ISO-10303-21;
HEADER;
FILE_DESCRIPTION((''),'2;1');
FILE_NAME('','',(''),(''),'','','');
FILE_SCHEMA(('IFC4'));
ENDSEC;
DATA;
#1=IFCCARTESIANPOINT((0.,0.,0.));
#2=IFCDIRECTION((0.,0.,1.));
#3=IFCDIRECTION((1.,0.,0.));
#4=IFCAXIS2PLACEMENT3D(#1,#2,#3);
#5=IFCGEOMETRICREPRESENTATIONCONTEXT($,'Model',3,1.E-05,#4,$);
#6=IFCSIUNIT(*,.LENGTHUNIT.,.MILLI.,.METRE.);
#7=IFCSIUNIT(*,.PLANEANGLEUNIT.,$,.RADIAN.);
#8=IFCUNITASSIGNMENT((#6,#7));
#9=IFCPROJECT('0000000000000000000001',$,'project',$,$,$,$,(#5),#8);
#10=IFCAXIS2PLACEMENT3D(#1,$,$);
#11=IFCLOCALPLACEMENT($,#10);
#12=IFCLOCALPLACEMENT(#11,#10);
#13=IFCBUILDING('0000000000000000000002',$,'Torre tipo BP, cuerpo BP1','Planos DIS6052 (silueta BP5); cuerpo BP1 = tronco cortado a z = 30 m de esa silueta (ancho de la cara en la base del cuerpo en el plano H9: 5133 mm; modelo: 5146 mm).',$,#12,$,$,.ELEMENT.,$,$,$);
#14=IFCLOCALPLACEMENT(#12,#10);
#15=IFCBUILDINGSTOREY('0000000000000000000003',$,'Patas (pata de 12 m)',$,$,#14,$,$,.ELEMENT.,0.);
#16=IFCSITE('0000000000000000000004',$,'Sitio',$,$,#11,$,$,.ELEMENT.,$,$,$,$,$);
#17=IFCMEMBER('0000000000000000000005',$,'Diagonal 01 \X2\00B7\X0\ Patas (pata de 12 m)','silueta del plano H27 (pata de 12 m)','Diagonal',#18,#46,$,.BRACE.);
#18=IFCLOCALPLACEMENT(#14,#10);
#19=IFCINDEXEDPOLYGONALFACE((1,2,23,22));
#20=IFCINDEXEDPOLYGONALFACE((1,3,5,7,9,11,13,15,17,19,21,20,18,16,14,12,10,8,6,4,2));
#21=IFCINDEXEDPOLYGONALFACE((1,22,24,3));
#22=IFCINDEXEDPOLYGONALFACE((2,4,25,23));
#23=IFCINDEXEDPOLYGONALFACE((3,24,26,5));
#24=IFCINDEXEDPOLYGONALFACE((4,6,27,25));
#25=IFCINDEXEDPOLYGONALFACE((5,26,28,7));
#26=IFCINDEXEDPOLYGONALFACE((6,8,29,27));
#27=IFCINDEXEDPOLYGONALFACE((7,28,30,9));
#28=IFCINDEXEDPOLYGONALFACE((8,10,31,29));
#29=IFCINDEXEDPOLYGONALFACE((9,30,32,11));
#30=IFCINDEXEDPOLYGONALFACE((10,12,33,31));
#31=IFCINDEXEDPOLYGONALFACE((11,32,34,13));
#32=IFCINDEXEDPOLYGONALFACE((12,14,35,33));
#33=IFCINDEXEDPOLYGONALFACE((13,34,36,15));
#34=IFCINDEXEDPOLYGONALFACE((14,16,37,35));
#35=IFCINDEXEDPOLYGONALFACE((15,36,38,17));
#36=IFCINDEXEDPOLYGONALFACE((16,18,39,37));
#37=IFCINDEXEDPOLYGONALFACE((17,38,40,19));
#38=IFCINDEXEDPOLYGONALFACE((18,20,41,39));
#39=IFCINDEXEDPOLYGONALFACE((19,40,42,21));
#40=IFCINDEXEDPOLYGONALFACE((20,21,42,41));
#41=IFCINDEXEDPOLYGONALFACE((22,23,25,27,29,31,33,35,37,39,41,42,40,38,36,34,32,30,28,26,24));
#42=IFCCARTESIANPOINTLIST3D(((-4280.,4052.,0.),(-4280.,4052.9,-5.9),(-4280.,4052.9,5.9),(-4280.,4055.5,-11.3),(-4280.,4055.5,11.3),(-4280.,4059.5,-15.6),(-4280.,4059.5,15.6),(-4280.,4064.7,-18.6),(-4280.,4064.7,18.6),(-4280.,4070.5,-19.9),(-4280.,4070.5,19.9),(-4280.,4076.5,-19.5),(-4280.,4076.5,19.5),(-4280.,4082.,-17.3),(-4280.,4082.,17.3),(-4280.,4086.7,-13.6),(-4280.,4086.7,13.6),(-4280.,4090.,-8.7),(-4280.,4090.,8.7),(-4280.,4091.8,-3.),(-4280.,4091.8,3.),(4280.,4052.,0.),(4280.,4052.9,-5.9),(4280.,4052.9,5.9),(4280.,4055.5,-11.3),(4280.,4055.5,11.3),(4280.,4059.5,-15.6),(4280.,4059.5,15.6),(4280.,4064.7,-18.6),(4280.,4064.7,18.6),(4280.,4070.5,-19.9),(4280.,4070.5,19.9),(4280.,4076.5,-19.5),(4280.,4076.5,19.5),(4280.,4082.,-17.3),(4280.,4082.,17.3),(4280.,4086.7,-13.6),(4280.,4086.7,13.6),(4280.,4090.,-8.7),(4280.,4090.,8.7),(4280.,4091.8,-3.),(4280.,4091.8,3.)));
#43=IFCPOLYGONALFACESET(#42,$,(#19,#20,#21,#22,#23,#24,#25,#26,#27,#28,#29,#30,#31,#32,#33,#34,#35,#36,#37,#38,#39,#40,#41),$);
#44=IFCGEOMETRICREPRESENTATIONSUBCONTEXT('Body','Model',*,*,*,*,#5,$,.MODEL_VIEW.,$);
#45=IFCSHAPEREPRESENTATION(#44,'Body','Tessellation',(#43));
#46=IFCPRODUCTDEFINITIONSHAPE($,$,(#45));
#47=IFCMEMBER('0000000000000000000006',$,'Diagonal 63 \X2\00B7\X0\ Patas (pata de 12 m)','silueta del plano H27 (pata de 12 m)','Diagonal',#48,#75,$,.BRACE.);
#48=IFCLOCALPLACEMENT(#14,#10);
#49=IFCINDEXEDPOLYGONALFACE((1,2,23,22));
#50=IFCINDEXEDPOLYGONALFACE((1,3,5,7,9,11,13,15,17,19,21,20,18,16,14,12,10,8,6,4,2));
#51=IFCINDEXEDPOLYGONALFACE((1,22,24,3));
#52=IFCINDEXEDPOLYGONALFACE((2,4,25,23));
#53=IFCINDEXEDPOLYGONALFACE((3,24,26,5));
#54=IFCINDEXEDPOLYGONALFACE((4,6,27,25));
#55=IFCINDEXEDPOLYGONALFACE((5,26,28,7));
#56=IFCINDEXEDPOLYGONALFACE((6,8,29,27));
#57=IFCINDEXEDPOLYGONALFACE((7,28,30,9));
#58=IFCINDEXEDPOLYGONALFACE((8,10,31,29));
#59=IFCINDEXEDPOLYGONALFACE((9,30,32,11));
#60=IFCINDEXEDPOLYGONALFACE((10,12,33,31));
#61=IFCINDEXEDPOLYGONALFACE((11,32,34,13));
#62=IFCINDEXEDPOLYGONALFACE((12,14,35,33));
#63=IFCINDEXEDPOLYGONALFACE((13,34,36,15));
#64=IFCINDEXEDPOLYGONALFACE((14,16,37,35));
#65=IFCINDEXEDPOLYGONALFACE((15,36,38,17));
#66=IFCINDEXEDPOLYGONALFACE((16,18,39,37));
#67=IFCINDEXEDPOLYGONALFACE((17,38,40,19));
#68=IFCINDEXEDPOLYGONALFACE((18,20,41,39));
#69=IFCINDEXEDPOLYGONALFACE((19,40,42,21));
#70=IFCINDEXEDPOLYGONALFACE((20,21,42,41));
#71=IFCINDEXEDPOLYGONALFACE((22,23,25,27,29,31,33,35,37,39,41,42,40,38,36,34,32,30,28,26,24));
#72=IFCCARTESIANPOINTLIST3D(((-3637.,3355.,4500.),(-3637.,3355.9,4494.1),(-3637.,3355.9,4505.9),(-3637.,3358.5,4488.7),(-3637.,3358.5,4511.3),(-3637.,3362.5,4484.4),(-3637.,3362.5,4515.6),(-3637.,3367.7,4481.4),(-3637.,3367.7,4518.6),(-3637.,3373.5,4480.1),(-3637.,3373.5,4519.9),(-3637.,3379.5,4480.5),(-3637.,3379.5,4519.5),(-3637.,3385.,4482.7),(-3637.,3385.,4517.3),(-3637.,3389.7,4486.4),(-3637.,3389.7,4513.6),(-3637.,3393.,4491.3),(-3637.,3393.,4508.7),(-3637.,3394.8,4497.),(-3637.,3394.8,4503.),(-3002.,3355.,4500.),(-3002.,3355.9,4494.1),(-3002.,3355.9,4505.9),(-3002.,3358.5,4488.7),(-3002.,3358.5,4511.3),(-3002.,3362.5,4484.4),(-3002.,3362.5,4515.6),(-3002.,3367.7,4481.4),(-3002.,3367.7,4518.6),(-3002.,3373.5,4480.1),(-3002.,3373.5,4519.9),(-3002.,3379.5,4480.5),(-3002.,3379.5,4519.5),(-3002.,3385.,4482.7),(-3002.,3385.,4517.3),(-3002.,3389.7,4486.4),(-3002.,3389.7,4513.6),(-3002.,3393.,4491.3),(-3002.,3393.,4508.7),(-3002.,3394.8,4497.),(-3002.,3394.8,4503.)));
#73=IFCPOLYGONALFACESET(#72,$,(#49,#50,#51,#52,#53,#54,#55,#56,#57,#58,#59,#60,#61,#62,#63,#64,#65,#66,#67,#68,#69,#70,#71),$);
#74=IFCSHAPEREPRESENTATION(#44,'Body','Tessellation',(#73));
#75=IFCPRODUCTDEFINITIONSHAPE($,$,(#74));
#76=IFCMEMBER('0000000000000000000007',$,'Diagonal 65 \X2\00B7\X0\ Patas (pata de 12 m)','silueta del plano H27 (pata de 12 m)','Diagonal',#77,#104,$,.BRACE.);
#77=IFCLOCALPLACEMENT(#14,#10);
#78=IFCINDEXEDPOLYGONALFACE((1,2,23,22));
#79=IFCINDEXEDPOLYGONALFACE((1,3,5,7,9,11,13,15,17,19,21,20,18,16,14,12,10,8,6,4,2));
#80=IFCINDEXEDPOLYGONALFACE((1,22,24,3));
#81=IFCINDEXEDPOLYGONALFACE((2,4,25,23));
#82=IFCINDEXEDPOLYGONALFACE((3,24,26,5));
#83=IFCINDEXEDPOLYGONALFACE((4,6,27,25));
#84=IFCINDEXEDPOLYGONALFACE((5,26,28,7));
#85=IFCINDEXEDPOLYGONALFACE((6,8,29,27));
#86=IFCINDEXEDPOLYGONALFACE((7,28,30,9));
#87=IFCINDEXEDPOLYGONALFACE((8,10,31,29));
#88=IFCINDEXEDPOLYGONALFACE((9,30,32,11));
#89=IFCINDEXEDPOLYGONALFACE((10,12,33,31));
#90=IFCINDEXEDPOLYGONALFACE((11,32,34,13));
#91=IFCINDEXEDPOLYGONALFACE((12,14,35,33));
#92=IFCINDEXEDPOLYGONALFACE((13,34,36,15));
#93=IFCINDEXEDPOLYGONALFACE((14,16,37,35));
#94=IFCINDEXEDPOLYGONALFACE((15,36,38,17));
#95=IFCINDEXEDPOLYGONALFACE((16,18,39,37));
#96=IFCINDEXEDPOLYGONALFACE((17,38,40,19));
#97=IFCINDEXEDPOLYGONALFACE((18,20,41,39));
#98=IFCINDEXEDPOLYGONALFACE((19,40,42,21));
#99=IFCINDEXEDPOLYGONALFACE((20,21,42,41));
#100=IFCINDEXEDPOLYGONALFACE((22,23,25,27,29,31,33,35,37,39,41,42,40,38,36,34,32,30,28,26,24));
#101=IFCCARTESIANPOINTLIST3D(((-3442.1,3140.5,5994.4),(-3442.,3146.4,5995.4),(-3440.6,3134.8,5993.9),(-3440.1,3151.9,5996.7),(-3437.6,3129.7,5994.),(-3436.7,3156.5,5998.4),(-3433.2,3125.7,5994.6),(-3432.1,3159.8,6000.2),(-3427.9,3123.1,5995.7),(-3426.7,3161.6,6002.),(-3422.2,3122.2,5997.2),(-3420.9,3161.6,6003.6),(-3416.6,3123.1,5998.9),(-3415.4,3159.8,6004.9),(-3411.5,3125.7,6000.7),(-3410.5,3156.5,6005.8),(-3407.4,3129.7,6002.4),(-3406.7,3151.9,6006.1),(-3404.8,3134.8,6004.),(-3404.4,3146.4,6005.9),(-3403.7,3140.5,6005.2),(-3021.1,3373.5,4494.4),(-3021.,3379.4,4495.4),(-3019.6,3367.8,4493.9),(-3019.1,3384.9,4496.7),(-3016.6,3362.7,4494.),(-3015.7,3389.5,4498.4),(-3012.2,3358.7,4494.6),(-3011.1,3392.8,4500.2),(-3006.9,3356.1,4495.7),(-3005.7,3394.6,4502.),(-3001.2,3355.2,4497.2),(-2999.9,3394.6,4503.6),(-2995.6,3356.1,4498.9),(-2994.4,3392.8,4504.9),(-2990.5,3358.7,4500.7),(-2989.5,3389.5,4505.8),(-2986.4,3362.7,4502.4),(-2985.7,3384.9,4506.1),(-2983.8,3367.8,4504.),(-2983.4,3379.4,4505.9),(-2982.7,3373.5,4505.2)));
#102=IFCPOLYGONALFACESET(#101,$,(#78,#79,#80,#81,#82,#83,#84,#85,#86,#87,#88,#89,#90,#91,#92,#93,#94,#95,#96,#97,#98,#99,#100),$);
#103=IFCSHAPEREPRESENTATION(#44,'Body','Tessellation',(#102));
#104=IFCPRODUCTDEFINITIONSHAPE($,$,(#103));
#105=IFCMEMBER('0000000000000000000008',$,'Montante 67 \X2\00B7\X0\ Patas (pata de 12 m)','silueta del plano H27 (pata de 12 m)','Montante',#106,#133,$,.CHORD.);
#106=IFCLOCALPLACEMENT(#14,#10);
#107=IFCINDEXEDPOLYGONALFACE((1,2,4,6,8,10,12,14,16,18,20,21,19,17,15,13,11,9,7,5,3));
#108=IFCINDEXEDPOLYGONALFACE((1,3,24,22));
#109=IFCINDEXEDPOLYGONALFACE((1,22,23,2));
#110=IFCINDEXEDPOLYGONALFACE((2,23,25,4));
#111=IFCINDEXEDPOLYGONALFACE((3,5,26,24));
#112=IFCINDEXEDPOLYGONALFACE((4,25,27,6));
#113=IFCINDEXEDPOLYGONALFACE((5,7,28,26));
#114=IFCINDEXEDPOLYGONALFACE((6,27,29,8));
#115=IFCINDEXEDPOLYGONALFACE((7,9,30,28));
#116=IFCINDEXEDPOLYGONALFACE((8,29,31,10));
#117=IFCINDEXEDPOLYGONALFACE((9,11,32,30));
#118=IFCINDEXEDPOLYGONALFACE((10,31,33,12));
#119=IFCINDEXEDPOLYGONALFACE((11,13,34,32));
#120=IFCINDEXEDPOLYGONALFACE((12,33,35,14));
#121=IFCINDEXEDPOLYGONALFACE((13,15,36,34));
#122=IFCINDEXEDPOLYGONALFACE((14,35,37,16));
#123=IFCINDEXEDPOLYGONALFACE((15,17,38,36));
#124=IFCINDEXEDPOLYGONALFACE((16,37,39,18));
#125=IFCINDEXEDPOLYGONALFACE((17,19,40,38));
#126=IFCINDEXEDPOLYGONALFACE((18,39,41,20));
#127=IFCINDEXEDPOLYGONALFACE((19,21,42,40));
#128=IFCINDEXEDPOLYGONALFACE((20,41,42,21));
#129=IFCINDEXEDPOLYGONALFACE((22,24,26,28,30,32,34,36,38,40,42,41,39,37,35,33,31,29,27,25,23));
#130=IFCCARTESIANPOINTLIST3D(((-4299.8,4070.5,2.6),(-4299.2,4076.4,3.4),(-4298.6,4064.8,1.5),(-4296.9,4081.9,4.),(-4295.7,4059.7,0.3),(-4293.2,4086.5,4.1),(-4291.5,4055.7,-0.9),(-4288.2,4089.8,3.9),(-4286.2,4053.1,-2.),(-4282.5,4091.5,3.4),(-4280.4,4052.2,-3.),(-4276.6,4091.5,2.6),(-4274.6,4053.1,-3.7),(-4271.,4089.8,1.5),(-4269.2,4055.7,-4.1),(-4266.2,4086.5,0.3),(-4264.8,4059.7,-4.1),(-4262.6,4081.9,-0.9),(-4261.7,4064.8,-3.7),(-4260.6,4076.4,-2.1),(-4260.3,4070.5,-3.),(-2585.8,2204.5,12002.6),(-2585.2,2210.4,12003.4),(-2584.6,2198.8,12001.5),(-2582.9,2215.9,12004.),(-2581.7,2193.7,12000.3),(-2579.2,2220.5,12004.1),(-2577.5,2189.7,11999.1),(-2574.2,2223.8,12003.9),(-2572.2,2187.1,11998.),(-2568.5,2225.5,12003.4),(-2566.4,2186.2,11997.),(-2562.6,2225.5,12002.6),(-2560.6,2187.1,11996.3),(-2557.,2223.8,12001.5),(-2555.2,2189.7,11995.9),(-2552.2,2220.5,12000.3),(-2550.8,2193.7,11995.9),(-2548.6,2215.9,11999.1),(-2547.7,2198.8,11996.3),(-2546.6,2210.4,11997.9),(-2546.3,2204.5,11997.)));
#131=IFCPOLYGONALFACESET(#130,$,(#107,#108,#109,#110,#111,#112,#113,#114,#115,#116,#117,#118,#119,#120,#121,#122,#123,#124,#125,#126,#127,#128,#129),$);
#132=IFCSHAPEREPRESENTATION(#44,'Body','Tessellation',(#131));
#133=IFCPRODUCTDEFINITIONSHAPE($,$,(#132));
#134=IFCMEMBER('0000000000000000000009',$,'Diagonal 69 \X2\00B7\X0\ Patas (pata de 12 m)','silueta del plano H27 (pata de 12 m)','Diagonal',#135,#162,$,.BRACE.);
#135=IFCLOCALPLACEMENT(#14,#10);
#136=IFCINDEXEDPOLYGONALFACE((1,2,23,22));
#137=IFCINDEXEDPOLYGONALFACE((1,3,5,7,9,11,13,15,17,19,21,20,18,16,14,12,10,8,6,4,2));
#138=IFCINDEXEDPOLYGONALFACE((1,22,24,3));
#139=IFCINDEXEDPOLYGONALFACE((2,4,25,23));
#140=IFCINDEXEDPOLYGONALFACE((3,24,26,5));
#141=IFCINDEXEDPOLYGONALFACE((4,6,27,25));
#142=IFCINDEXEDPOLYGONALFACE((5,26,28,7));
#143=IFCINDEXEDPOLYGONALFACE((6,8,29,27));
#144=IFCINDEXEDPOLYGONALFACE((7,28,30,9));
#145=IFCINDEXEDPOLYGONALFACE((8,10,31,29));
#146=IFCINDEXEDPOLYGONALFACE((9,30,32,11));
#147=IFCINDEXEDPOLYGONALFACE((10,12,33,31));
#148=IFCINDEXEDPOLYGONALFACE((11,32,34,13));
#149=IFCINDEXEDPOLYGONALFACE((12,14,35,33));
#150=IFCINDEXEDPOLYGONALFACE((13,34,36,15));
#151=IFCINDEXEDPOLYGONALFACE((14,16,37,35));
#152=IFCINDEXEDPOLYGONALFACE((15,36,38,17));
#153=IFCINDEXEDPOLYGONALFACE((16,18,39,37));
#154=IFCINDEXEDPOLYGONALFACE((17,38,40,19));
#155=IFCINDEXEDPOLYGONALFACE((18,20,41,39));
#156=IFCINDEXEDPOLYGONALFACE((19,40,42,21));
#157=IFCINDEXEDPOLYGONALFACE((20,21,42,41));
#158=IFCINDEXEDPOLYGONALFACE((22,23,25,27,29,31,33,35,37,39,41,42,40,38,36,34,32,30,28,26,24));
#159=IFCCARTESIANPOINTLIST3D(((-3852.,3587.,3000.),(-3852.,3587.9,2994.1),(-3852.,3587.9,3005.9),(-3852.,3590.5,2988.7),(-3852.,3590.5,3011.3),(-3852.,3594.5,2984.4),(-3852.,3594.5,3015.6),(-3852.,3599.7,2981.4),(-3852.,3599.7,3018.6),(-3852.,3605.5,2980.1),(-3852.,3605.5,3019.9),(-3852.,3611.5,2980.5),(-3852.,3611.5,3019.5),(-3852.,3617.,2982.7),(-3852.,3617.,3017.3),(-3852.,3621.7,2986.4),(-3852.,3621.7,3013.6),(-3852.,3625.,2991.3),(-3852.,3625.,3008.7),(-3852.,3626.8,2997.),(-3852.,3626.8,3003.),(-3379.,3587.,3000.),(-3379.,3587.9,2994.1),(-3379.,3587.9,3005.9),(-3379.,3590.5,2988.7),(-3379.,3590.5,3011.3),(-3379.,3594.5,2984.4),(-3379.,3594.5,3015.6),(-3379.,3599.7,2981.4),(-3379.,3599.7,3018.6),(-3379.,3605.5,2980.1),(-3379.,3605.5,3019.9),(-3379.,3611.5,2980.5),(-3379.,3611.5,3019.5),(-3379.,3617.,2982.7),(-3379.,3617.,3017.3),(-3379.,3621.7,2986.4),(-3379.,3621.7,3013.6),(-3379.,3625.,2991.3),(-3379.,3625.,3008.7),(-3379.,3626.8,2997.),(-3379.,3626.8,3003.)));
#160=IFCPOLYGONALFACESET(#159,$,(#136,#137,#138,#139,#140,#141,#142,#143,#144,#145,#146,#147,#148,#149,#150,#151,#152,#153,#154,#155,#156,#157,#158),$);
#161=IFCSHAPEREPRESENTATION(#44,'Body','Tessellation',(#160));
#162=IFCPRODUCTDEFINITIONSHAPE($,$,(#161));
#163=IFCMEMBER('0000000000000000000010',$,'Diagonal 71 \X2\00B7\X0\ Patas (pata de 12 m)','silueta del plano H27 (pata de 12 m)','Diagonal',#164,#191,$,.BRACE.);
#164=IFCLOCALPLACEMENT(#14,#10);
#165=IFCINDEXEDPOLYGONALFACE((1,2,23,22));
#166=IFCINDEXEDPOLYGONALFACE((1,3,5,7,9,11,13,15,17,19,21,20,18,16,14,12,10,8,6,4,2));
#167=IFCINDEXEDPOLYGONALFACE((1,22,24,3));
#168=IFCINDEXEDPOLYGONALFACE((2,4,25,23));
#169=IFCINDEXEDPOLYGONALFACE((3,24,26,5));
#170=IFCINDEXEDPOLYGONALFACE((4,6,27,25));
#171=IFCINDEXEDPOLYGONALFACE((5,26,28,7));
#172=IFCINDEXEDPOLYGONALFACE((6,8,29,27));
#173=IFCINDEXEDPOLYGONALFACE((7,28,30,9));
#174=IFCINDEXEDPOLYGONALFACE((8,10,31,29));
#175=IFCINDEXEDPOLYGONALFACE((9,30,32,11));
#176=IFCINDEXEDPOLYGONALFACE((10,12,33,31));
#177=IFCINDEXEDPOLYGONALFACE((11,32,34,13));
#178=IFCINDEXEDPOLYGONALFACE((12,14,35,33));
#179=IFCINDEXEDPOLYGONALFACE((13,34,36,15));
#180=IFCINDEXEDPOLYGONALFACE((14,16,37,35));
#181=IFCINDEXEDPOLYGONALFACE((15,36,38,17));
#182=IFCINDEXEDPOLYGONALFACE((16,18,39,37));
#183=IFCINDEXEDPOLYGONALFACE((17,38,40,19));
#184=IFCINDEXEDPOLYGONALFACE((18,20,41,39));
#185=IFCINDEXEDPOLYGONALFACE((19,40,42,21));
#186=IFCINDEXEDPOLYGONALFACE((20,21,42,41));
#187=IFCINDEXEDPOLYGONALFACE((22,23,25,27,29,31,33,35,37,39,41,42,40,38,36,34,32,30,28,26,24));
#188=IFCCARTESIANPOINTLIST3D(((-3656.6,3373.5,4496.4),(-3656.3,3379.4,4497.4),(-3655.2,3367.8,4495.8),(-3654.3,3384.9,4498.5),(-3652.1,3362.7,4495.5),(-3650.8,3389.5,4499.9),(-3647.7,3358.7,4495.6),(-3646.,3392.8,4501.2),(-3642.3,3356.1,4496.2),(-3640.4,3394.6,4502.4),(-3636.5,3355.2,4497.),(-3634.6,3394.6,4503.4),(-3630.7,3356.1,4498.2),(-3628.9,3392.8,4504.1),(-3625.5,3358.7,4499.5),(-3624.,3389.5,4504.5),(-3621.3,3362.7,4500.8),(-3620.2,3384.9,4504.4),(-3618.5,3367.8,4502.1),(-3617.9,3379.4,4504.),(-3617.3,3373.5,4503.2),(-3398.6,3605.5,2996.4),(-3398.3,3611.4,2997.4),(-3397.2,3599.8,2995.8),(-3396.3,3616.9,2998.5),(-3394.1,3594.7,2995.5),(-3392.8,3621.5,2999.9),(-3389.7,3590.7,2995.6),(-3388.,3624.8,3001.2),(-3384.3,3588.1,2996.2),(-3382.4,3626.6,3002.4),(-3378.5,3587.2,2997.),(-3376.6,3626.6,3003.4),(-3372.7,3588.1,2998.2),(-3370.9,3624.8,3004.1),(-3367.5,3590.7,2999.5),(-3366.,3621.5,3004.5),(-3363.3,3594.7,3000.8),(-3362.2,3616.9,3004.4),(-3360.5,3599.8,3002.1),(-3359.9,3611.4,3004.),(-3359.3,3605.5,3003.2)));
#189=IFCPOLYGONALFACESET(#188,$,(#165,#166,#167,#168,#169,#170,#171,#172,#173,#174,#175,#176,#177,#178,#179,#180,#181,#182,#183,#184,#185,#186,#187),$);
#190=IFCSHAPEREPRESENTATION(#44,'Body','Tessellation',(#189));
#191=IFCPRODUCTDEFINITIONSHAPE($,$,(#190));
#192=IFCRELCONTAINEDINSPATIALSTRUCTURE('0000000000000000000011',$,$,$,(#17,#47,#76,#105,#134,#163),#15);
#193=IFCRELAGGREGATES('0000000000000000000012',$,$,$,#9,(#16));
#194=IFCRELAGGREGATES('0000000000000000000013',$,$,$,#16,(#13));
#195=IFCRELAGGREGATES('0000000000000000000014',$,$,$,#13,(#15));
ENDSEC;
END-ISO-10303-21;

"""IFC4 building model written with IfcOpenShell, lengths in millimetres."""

from ifc_helpers import new_model, si_unit, frame, origin, origin_with_axes, place, context, subcontext, project, spatial, circle, extrude, element, save


model = new_model("IFC4")

# Units and contexts
model_context = context("Model", 3, precision=1e-05, world=origin_with_axes())
body_context = subcontext(model_context, "Body", "Model", "MODEL_VIEW")
ifc_project = project(units=[si_unit("LENGTHUNIT", "METRE", prefix="MILLI"), si_unit("PLANEANGLEUNIT", "RADIAN")], contexts=[model_context])

# Site, building, storey
site_placement = place(None, origin())
site = spatial("IfcSite", under=ifc_project, at=site_placement, Name="Sitio", CompositionType="ELEMENT")
building_placement = place(site_placement, origin())
building = spatial("IfcBuilding", under=site, at=building_placement, Name="Torre tipo BP, cuerpo BP1", Description="Planos DIS6052 (silueta BP5); cuerpo BP1 = tronco cortado a z = 30 m de esa silueta (ancho de la cara en la base del cuerpo en el plano H9: 5133 mm; modelo: 5146 mm).", CompositionType="ELEMENT")
storey_placement = place(building_placement, origin())
storey = spatial("IfcBuildingStorey", under=building, at=storey_placement, Name="Patas (pata de 12 m)", CompositionType="ELEMENT", Elevation=0.0)

# Members
member_1_placement = place(storey_placement, frame((-4280.0, 4072.0, 0.0), z_axis=(1.0, 0.0, 0.0), x_axis=(0.0, -1.0, 0.0)))
element("IfcMember", 1, at=member_1_placement, inside=storey, Name="Diagonal 01 · Patas (pata de 12 m)", Description="silueta del plano H27 (pata de 12 m)", ObjectType="Diagonal", PredefinedType="BRACE", context=body_context, shape_type="SweptSolid", body=[
    extrude(circle(Radius=20.0), None, (0.0, 0.0, 1.0), 8560.0),
])
member_2_placement = place(storey_placement, frame((-3637.0, 3375.0, 4500.0), z_axis=(1.0, 0.0, 0.0), x_axis=(0.0, -1.0, 0.0)))
element("IfcMember", 2, at=member_2_placement, inside=storey, Name="Diagonal 63 · Patas (pata de 12 m)", Description="silueta del plano H27 (pata de 12 m)", ObjectType="Diagonal", PredefinedType="BRACE", context=body_context, shape_type="SweptSolid", body=[
    extrude(circle(Radius=20.0), None, (0.0, 0.0, 1.0), 635.0),
])
member_3_placement = place(storey_placement, frame((-3002.0, 3375.0, 4500.0), z_axis=(-0.267253, -0.14791, 0.952207), x_axis=(0.039969, -0.989001, -0.142407)))
element("IfcMember", 3, at=member_3_placement, inside=storey, Name="Diagonal 65 · Patas (pata de 12 m)", Description="silueta del plano H27 (pata de 12 m)", ObjectType="Diagonal", PredefinedType="BRACE", context=body_context, shape_type="SweptSolid", body=[
    extrude(circle(Radius=20.0), None, (0.0, 0.0, 1.0), 1575.3),
])
member_4_placement = place(storey_placement, frame((-4280.0, 4072.0, 0.0), z_axis=(0.139752, -0.152146, 0.978428), x_axis=(-0.021513, -0.988358, -0.150617)))
element("IfcMember", 4, at=member_4_placement, inside=storey, Name="Montante 67 · Patas (pata de 12 m)", Description="silueta del plano H27 (pata de 12 m)", ObjectType="Montante", PredefinedType="CHORD", context=body_context, shape_type="SweptSolid", body=[
    extrude(circle(Radius=20.0), None, (0.0, 0.0, 1.0), 12264.6),
])
member_5_placement = place(storey_placement, frame((-3852.0, 3607.0, 3000.0), z_axis=(1.0, 0.0, 0.0), x_axis=(0.0, -1.0, 0.0)))
element("IfcMember", 5, at=member_5_placement, inside=storey, Name="Diagonal 69 · Patas (pata de 12 m)", Description="silueta del plano H27 (pata de 12 m)", ObjectType="Diagonal", PredefinedType="BRACE", context=body_context, shape_type="SweptSolid", body=[
    extrude(circle(Radius=20.0), None, (0.0, 0.0, 1.0), 473.0),
])
member_6_placement = place(storey_placement, frame((-3379.0, 3607.0, 3000.0), z_axis=(-0.167575, -0.150688, 0.974275), x_axis=(0.025543, -0.988581, -0.148507)))
element("IfcMember", 6, at=member_6_placement, inside=storey, Name="Diagonal 71 · Patas (pata de 12 m)", Description="silueta del plano H27 (pata de 12 m)", ObjectType="Diagonal", PredefinedType="BRACE", context=body_context, shape_type="SweptSolid", body=[
    extrude(circle(Radius=20.0), None, (0.0, 0.0, 1.0), 1539.6),
])

save(model, "model.ifc")
